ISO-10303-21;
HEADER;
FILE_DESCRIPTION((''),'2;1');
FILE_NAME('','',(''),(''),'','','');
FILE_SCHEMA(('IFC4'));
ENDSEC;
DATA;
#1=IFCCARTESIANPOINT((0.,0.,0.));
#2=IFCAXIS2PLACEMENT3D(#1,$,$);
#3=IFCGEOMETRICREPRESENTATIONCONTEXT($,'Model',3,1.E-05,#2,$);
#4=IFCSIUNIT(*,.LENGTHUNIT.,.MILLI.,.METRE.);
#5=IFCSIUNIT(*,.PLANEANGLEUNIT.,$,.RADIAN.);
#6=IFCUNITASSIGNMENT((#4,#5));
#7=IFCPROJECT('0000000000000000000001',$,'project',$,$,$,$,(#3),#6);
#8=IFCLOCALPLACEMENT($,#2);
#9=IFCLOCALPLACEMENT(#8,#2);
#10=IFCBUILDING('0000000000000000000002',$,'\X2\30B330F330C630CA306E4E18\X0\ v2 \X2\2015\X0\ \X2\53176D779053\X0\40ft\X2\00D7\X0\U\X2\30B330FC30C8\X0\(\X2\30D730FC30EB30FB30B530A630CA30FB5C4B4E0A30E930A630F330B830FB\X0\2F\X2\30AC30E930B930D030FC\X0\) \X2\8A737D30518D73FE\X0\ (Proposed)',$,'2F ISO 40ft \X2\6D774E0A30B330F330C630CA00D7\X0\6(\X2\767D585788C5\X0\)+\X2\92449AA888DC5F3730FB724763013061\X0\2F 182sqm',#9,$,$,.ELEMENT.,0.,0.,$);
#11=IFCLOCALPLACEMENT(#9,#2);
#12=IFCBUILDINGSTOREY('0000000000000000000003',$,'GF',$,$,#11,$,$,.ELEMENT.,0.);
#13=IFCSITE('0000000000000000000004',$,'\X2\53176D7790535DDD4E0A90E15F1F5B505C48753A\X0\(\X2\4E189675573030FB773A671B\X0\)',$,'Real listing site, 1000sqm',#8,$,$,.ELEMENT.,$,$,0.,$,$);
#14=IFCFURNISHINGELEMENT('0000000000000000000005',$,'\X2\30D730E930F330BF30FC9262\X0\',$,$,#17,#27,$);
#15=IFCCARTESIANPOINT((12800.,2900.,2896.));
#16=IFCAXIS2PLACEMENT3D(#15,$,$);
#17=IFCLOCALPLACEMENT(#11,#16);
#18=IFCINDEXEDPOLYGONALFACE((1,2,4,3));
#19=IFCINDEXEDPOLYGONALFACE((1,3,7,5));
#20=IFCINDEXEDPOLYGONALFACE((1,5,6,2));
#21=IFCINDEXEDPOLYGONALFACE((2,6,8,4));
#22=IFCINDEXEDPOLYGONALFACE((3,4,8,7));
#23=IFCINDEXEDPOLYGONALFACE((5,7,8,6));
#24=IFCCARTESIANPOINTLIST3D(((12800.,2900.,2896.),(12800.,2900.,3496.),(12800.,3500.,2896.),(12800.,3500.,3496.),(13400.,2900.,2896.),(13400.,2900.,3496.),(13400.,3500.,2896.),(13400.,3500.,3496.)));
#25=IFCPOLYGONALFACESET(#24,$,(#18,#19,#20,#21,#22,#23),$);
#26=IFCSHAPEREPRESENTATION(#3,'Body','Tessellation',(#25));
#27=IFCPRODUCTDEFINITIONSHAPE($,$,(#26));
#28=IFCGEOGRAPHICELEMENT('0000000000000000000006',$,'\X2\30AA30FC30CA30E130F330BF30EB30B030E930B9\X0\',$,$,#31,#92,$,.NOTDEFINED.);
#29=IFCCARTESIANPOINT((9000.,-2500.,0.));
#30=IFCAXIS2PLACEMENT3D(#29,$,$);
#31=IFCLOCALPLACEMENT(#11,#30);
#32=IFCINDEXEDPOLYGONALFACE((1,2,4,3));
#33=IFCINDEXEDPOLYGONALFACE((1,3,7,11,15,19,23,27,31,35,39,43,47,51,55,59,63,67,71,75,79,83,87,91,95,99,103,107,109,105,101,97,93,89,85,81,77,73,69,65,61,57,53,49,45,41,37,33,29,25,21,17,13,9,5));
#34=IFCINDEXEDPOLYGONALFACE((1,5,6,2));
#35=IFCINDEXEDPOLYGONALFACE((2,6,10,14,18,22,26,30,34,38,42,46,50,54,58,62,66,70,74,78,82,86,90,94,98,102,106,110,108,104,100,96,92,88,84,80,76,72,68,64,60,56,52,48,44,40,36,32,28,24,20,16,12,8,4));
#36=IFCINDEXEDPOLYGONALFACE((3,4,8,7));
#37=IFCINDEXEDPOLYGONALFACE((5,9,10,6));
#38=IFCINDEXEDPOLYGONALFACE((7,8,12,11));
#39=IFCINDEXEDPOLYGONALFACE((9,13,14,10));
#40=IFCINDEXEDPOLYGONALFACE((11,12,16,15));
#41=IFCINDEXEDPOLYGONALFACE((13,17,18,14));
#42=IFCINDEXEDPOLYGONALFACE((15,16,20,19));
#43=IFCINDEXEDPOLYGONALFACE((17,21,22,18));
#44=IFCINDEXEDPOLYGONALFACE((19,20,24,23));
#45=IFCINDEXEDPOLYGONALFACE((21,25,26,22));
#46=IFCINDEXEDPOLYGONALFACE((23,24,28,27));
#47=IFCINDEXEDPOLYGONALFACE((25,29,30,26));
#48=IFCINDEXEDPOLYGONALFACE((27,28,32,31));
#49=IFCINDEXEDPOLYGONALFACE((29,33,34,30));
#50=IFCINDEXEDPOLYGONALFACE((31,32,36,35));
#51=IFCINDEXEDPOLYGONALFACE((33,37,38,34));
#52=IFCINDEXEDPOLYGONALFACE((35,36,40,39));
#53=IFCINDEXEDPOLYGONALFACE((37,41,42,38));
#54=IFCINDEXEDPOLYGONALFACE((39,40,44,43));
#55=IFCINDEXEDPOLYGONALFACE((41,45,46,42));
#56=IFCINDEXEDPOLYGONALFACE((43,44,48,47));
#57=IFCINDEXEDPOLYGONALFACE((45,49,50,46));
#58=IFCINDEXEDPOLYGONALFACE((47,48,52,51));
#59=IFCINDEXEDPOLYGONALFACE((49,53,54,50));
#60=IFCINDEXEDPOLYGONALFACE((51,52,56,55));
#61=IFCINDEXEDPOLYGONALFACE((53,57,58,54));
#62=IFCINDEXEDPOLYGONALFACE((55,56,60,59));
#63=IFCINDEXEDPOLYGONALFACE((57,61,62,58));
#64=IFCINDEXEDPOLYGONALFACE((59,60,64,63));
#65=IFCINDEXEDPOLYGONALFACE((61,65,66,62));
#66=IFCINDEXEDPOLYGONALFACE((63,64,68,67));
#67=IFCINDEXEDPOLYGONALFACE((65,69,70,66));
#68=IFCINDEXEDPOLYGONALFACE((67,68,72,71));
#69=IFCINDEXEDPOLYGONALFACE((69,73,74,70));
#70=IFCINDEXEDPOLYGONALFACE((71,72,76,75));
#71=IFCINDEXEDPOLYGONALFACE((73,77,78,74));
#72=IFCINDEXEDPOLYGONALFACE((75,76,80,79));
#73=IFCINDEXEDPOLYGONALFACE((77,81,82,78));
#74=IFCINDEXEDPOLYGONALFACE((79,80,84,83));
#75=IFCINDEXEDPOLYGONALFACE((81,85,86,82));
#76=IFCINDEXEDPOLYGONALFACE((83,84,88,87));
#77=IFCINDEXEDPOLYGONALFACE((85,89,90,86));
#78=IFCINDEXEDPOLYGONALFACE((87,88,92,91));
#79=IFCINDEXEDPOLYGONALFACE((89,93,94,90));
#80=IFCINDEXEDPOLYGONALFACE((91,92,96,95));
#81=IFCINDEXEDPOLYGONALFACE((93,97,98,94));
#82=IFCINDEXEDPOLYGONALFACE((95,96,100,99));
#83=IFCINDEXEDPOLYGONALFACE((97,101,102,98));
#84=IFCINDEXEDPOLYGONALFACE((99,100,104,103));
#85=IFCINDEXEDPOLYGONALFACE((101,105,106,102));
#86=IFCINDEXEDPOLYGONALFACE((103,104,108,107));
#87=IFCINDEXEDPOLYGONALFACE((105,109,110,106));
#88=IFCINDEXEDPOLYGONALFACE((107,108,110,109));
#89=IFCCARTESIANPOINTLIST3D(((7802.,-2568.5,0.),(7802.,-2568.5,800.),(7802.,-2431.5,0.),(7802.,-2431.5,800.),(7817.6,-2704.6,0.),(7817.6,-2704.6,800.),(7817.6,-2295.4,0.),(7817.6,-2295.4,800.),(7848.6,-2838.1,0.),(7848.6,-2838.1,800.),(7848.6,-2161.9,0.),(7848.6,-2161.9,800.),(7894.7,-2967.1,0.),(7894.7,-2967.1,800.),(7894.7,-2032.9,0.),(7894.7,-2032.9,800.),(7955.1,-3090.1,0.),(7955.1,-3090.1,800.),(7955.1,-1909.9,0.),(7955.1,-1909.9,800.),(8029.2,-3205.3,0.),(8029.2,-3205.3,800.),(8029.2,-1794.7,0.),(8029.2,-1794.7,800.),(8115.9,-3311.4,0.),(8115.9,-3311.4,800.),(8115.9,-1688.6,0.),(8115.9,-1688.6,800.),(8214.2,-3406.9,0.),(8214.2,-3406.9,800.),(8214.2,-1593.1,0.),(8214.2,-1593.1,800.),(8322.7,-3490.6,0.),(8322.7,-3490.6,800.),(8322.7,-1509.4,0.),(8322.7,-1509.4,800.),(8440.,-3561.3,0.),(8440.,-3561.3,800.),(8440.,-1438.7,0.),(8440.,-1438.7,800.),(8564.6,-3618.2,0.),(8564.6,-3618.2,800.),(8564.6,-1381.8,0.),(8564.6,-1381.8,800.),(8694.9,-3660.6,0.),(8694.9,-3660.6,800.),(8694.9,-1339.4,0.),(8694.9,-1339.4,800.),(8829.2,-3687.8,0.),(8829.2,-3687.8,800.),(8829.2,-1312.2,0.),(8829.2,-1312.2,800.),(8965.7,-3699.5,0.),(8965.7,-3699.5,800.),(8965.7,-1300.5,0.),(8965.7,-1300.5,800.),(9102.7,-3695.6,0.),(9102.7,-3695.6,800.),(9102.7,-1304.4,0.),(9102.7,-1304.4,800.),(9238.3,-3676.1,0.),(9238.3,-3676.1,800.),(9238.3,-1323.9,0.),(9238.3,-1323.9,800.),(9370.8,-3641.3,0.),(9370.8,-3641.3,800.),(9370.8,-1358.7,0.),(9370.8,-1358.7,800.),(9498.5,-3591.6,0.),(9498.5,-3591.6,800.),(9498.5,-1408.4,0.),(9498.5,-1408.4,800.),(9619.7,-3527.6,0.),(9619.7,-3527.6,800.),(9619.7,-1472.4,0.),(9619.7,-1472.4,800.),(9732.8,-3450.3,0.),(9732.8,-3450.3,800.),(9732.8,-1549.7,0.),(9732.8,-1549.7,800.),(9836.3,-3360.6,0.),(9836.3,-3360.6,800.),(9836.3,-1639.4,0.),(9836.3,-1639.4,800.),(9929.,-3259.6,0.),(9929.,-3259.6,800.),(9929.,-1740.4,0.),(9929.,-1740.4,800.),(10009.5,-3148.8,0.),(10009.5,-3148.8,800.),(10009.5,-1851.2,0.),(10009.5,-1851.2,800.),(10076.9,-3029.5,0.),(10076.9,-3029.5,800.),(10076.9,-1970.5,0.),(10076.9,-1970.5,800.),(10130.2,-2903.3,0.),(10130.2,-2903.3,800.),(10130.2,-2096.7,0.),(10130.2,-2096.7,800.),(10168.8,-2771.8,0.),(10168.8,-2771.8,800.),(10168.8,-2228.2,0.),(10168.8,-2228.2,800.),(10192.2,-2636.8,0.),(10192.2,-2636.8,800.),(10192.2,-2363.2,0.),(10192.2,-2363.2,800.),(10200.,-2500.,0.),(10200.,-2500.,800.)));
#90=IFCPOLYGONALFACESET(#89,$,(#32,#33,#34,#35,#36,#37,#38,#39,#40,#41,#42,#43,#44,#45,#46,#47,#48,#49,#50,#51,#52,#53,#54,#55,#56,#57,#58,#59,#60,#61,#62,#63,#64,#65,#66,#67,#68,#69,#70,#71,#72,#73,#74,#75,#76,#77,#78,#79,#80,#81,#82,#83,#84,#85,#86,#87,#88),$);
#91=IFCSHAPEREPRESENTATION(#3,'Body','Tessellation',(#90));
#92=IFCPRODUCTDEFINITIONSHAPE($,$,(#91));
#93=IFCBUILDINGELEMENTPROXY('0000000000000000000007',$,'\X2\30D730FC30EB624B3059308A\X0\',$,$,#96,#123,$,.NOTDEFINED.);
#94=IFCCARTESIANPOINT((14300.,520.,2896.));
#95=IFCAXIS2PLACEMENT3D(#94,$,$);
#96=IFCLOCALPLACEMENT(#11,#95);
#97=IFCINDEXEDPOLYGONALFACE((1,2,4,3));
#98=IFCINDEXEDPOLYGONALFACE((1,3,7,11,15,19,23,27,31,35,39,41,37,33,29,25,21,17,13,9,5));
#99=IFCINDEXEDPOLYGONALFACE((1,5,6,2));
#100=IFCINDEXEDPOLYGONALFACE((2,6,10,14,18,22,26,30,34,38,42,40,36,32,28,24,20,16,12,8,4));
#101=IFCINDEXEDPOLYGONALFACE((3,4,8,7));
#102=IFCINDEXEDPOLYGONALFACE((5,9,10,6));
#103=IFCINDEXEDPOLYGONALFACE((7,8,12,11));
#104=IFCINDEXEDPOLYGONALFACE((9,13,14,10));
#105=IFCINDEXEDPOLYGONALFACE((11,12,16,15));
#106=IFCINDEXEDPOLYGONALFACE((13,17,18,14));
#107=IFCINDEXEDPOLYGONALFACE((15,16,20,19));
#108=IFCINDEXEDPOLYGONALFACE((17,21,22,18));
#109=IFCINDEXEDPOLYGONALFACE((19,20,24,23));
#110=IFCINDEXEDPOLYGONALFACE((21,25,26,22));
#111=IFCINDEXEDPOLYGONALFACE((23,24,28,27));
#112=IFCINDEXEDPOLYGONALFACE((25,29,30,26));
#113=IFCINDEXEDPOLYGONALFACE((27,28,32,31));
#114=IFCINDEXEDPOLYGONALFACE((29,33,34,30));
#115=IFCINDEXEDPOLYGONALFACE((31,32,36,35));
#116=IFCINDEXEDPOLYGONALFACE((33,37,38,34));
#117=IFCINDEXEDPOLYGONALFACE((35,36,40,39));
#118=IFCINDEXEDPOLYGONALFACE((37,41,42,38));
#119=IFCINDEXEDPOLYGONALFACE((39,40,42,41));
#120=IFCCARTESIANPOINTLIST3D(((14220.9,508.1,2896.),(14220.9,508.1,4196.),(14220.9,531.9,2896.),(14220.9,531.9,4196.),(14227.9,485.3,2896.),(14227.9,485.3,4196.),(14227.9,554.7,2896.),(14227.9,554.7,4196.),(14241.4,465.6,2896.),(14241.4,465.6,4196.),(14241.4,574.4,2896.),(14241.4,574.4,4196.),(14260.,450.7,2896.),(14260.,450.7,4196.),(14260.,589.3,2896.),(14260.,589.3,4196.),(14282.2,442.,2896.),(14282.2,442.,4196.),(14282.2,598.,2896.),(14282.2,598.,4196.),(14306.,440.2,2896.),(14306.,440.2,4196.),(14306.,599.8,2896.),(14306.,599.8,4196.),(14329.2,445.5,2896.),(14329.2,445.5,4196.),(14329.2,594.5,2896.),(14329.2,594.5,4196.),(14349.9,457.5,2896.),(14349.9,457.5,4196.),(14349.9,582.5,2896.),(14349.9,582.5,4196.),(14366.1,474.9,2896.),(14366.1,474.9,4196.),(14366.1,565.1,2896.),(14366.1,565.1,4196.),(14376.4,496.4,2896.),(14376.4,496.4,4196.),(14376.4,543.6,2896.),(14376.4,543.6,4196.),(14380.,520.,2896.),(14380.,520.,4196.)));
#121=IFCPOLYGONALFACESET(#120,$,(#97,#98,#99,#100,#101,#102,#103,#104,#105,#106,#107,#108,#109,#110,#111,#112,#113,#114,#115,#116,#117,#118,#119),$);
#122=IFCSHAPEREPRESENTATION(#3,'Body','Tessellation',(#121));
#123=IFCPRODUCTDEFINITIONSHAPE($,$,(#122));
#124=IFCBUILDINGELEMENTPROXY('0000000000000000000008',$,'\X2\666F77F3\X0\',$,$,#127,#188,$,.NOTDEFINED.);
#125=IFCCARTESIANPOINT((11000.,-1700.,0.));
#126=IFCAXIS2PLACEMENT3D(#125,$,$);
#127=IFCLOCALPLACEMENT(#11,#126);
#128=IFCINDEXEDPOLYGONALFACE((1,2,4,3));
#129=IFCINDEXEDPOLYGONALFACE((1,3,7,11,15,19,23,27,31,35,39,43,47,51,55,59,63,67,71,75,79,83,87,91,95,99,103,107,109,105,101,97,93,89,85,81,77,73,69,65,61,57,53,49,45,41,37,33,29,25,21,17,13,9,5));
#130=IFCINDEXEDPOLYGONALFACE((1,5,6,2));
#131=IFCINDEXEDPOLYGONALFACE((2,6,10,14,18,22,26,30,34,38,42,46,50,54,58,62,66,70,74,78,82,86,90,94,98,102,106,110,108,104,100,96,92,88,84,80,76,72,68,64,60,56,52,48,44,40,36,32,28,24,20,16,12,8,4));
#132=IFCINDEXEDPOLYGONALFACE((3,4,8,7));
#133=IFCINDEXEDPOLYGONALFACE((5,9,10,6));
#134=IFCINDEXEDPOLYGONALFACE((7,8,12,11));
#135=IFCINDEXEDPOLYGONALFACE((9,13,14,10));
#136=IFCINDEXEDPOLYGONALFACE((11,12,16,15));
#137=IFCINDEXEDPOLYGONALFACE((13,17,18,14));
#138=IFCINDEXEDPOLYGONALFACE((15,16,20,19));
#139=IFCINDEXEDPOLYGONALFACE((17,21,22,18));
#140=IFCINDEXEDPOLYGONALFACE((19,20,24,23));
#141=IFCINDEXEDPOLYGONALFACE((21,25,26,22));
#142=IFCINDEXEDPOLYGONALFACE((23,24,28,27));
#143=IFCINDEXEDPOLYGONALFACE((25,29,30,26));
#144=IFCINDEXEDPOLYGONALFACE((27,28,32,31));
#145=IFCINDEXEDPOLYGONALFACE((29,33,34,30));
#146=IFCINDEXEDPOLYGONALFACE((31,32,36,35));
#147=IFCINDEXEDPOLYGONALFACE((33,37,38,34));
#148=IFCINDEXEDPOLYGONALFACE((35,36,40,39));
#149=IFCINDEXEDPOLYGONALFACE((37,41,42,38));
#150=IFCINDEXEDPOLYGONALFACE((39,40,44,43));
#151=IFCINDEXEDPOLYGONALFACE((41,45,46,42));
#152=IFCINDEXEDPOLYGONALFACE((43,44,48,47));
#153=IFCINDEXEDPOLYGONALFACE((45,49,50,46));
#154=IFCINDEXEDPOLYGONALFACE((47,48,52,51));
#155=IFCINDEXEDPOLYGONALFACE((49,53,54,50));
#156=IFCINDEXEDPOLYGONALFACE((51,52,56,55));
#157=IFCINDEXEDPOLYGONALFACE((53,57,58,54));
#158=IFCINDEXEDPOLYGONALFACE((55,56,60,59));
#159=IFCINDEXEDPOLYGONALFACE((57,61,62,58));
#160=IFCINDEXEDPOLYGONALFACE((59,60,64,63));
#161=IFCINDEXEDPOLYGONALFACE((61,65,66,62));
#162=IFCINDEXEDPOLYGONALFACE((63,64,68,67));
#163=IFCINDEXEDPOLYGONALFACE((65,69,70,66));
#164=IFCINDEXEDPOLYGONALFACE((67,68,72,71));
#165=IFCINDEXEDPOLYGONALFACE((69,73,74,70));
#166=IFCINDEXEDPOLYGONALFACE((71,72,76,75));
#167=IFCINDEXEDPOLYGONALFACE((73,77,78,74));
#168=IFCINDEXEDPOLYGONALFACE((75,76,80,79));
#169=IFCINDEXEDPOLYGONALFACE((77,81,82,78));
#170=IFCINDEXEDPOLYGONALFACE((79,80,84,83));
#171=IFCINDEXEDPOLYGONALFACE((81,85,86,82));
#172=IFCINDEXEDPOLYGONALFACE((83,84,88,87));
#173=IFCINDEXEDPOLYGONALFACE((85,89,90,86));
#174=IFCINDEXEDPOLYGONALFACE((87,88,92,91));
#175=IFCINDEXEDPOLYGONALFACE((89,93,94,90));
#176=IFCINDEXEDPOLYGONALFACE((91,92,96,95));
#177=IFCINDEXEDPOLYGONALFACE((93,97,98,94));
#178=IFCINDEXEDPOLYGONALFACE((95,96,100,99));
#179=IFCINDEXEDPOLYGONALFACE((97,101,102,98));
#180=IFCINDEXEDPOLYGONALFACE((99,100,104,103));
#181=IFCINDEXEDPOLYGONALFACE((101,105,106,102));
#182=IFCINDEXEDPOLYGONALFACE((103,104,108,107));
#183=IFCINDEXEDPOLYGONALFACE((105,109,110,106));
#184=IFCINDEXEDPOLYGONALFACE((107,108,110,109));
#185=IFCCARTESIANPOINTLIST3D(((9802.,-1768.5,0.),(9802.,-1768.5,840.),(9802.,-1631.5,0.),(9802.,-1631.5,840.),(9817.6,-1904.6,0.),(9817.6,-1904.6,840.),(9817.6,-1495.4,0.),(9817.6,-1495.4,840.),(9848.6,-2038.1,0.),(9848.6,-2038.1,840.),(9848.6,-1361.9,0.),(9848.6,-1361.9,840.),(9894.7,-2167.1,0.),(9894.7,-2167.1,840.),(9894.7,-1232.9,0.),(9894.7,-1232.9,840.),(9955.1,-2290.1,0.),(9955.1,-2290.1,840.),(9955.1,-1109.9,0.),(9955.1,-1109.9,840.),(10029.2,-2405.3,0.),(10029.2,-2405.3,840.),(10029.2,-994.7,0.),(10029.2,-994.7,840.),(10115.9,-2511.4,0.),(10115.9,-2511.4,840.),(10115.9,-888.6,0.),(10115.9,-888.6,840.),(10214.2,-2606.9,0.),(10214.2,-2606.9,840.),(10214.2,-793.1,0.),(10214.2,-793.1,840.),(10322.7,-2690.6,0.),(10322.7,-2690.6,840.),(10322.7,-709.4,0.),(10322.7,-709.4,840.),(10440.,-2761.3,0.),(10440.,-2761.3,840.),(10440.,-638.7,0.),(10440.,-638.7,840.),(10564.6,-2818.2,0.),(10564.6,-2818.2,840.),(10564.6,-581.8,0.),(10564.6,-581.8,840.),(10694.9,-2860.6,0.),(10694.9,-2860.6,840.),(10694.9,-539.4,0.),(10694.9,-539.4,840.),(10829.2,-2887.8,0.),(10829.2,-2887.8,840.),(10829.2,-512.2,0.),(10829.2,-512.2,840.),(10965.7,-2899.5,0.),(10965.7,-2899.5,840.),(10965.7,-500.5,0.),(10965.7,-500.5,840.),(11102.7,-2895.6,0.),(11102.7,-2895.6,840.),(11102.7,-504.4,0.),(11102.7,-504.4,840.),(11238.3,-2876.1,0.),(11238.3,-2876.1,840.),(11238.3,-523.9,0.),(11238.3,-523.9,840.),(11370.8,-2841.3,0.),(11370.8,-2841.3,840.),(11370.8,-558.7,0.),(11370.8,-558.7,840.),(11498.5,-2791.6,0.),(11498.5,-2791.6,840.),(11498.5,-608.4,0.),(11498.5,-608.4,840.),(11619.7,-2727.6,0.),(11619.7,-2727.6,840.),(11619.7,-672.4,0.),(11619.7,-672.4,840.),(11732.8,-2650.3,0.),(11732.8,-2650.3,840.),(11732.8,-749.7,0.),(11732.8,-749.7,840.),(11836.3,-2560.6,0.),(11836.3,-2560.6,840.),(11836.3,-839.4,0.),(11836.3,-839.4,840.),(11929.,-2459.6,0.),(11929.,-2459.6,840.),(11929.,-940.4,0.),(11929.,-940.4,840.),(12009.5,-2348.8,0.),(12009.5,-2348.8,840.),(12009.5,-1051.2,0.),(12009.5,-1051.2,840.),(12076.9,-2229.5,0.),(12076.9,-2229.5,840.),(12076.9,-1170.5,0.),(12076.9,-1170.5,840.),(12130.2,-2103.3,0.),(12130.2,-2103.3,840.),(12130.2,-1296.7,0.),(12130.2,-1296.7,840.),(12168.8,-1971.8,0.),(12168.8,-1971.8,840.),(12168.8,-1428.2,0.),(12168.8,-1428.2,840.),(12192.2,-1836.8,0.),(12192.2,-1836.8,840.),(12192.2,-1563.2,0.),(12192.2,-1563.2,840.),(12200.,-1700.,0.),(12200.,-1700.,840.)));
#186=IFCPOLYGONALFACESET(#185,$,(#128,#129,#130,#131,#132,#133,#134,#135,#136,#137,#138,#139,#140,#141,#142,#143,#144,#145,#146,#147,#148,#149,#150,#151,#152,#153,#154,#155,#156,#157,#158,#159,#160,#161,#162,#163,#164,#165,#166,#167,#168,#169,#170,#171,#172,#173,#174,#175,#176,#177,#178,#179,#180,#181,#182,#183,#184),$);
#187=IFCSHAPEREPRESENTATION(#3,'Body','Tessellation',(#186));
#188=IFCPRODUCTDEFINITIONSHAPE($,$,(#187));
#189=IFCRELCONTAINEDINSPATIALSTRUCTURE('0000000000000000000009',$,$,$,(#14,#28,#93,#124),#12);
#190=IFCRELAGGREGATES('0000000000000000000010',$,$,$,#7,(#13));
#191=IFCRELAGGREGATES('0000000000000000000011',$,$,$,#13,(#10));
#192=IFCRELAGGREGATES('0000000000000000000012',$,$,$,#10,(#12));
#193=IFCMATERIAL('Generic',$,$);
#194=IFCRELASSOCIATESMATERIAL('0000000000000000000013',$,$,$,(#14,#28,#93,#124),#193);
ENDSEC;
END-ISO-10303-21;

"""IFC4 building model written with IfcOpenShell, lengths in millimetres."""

from ifc_helpers import new_model, si_unit, frame, frame_2d, origin, origin_2d, place, context, project, spatial, rectangle, circle, extrude, material, element, save


model = new_model("IFC4")

# Units and contexts
model_context = context("Model", 3, precision=1e-05, world=origin())
ifc_project = project(units=[si_unit("LENGTHUNIT", "METRE", prefix="MILLI"), si_unit("PLANEANGLEUNIT", "RADIAN")], contexts=[model_context])

# Site, building, storey
site_placement = place(None, origin())
site = spatial("IfcSite", under=ifc_project, at=site_placement, Name="北海道川上郡弟子屈町(丘陵地・眺望)", ObjectType="Real listing site, 1000sqm", CompositionType="ELEMENT", RefElevation=0.0)
building_placement = place(site_placement, origin())
building = spatial("IfcBuilding", under=site, at=building_placement, Name="コンテナの丘 v2 ― 北海道40ft×Uコート(プール・サウナ・屋上ラウンジ・2Fガラスバー) 詳細再現 (Proposed)", ObjectType="2F ISO 40ft 海上コンテナ×6(白塗装)+鉄骨補強・片持ち2F 182sqm", CompositionType="ELEMENT", ElevationOfRefHeight=0.0, ElevationOfTerrain=0.0)
storey_placement = place(building_placement, origin())
storey = spatial("IfcBuildingStorey", under=building, at=storey_placement, Name="GF", CompositionType="ELEMENT", Elevation=0.0)

# Shared definitions
ifc_material = material(Name="Generic")

# Furnishing element
furnishing_1_placement = place(storey_placement, frame((12800.0, 2900.0, 2896.0)))
element("IfcFurnishingElement", 1, at=furnishing_1_placement, inside=storey, material=ifc_material, Name="プランター鉢", context=model_context, shape_type="SweptSolid", body=[
    extrude(rectangle(XDim=600.0, YDim=600.0, at=frame_2d((300.0, 300.0))), frame((12800.0, 2900.0, 2896.0)), (0.0, 0.0, 1.0), 600.0),
])

# Geographic element
geographic_element_1_placement = place(storey_placement, frame((9000.0, -2500.0, 0.0)))
element("IfcGeographicElement", 2, at=geographic_element_1_placement, inside=storey, material=ifc_material, Name="オーナメンタルグラス", PredefinedType="NOTDEFINED", context=model_context, shape_type="SweptSolid", body=[
    extrude(circle(Radius=1200.0, at=origin_2d()), frame((9000.0, -2500.0, 0.0)), (0.0, 0.0, 1.0), 800.0),
])

# Building element proxies
proxy_1_placement = place(storey_placement, frame((14300.0, 520.0, 2896.0)))
element("IfcBuildingElementProxy", 3, at=proxy_1_placement, inside=storey, material=ifc_material, Name="プール手すり", PredefinedType="NOTDEFINED", context=model_context, shape_type="SweptSolid", body=[
    extrude(circle(Radius=80.0, at=origin_2d()), frame((14300.0, 520.0, 2896.0)), (0.0, 0.0, 1.0), 1300.0),
])
proxy_2_placement = place(storey_placement, frame((11000.0, -1700.0, 0.0)))
element("IfcBuildingElementProxy", 4, at=proxy_2_placement, inside=storey, material=ifc_material, Name="景石", PredefinedType="NOTDEFINED", context=model_context, shape_type="SweptSolid", body=[
    extrude(circle(Radius=1200.0, at=origin_2d()), frame((11000.0, -1700.0, 0.0)), (0.0, 0.0, 1.0), 840.0),
])

save(model, "model.ifc")
